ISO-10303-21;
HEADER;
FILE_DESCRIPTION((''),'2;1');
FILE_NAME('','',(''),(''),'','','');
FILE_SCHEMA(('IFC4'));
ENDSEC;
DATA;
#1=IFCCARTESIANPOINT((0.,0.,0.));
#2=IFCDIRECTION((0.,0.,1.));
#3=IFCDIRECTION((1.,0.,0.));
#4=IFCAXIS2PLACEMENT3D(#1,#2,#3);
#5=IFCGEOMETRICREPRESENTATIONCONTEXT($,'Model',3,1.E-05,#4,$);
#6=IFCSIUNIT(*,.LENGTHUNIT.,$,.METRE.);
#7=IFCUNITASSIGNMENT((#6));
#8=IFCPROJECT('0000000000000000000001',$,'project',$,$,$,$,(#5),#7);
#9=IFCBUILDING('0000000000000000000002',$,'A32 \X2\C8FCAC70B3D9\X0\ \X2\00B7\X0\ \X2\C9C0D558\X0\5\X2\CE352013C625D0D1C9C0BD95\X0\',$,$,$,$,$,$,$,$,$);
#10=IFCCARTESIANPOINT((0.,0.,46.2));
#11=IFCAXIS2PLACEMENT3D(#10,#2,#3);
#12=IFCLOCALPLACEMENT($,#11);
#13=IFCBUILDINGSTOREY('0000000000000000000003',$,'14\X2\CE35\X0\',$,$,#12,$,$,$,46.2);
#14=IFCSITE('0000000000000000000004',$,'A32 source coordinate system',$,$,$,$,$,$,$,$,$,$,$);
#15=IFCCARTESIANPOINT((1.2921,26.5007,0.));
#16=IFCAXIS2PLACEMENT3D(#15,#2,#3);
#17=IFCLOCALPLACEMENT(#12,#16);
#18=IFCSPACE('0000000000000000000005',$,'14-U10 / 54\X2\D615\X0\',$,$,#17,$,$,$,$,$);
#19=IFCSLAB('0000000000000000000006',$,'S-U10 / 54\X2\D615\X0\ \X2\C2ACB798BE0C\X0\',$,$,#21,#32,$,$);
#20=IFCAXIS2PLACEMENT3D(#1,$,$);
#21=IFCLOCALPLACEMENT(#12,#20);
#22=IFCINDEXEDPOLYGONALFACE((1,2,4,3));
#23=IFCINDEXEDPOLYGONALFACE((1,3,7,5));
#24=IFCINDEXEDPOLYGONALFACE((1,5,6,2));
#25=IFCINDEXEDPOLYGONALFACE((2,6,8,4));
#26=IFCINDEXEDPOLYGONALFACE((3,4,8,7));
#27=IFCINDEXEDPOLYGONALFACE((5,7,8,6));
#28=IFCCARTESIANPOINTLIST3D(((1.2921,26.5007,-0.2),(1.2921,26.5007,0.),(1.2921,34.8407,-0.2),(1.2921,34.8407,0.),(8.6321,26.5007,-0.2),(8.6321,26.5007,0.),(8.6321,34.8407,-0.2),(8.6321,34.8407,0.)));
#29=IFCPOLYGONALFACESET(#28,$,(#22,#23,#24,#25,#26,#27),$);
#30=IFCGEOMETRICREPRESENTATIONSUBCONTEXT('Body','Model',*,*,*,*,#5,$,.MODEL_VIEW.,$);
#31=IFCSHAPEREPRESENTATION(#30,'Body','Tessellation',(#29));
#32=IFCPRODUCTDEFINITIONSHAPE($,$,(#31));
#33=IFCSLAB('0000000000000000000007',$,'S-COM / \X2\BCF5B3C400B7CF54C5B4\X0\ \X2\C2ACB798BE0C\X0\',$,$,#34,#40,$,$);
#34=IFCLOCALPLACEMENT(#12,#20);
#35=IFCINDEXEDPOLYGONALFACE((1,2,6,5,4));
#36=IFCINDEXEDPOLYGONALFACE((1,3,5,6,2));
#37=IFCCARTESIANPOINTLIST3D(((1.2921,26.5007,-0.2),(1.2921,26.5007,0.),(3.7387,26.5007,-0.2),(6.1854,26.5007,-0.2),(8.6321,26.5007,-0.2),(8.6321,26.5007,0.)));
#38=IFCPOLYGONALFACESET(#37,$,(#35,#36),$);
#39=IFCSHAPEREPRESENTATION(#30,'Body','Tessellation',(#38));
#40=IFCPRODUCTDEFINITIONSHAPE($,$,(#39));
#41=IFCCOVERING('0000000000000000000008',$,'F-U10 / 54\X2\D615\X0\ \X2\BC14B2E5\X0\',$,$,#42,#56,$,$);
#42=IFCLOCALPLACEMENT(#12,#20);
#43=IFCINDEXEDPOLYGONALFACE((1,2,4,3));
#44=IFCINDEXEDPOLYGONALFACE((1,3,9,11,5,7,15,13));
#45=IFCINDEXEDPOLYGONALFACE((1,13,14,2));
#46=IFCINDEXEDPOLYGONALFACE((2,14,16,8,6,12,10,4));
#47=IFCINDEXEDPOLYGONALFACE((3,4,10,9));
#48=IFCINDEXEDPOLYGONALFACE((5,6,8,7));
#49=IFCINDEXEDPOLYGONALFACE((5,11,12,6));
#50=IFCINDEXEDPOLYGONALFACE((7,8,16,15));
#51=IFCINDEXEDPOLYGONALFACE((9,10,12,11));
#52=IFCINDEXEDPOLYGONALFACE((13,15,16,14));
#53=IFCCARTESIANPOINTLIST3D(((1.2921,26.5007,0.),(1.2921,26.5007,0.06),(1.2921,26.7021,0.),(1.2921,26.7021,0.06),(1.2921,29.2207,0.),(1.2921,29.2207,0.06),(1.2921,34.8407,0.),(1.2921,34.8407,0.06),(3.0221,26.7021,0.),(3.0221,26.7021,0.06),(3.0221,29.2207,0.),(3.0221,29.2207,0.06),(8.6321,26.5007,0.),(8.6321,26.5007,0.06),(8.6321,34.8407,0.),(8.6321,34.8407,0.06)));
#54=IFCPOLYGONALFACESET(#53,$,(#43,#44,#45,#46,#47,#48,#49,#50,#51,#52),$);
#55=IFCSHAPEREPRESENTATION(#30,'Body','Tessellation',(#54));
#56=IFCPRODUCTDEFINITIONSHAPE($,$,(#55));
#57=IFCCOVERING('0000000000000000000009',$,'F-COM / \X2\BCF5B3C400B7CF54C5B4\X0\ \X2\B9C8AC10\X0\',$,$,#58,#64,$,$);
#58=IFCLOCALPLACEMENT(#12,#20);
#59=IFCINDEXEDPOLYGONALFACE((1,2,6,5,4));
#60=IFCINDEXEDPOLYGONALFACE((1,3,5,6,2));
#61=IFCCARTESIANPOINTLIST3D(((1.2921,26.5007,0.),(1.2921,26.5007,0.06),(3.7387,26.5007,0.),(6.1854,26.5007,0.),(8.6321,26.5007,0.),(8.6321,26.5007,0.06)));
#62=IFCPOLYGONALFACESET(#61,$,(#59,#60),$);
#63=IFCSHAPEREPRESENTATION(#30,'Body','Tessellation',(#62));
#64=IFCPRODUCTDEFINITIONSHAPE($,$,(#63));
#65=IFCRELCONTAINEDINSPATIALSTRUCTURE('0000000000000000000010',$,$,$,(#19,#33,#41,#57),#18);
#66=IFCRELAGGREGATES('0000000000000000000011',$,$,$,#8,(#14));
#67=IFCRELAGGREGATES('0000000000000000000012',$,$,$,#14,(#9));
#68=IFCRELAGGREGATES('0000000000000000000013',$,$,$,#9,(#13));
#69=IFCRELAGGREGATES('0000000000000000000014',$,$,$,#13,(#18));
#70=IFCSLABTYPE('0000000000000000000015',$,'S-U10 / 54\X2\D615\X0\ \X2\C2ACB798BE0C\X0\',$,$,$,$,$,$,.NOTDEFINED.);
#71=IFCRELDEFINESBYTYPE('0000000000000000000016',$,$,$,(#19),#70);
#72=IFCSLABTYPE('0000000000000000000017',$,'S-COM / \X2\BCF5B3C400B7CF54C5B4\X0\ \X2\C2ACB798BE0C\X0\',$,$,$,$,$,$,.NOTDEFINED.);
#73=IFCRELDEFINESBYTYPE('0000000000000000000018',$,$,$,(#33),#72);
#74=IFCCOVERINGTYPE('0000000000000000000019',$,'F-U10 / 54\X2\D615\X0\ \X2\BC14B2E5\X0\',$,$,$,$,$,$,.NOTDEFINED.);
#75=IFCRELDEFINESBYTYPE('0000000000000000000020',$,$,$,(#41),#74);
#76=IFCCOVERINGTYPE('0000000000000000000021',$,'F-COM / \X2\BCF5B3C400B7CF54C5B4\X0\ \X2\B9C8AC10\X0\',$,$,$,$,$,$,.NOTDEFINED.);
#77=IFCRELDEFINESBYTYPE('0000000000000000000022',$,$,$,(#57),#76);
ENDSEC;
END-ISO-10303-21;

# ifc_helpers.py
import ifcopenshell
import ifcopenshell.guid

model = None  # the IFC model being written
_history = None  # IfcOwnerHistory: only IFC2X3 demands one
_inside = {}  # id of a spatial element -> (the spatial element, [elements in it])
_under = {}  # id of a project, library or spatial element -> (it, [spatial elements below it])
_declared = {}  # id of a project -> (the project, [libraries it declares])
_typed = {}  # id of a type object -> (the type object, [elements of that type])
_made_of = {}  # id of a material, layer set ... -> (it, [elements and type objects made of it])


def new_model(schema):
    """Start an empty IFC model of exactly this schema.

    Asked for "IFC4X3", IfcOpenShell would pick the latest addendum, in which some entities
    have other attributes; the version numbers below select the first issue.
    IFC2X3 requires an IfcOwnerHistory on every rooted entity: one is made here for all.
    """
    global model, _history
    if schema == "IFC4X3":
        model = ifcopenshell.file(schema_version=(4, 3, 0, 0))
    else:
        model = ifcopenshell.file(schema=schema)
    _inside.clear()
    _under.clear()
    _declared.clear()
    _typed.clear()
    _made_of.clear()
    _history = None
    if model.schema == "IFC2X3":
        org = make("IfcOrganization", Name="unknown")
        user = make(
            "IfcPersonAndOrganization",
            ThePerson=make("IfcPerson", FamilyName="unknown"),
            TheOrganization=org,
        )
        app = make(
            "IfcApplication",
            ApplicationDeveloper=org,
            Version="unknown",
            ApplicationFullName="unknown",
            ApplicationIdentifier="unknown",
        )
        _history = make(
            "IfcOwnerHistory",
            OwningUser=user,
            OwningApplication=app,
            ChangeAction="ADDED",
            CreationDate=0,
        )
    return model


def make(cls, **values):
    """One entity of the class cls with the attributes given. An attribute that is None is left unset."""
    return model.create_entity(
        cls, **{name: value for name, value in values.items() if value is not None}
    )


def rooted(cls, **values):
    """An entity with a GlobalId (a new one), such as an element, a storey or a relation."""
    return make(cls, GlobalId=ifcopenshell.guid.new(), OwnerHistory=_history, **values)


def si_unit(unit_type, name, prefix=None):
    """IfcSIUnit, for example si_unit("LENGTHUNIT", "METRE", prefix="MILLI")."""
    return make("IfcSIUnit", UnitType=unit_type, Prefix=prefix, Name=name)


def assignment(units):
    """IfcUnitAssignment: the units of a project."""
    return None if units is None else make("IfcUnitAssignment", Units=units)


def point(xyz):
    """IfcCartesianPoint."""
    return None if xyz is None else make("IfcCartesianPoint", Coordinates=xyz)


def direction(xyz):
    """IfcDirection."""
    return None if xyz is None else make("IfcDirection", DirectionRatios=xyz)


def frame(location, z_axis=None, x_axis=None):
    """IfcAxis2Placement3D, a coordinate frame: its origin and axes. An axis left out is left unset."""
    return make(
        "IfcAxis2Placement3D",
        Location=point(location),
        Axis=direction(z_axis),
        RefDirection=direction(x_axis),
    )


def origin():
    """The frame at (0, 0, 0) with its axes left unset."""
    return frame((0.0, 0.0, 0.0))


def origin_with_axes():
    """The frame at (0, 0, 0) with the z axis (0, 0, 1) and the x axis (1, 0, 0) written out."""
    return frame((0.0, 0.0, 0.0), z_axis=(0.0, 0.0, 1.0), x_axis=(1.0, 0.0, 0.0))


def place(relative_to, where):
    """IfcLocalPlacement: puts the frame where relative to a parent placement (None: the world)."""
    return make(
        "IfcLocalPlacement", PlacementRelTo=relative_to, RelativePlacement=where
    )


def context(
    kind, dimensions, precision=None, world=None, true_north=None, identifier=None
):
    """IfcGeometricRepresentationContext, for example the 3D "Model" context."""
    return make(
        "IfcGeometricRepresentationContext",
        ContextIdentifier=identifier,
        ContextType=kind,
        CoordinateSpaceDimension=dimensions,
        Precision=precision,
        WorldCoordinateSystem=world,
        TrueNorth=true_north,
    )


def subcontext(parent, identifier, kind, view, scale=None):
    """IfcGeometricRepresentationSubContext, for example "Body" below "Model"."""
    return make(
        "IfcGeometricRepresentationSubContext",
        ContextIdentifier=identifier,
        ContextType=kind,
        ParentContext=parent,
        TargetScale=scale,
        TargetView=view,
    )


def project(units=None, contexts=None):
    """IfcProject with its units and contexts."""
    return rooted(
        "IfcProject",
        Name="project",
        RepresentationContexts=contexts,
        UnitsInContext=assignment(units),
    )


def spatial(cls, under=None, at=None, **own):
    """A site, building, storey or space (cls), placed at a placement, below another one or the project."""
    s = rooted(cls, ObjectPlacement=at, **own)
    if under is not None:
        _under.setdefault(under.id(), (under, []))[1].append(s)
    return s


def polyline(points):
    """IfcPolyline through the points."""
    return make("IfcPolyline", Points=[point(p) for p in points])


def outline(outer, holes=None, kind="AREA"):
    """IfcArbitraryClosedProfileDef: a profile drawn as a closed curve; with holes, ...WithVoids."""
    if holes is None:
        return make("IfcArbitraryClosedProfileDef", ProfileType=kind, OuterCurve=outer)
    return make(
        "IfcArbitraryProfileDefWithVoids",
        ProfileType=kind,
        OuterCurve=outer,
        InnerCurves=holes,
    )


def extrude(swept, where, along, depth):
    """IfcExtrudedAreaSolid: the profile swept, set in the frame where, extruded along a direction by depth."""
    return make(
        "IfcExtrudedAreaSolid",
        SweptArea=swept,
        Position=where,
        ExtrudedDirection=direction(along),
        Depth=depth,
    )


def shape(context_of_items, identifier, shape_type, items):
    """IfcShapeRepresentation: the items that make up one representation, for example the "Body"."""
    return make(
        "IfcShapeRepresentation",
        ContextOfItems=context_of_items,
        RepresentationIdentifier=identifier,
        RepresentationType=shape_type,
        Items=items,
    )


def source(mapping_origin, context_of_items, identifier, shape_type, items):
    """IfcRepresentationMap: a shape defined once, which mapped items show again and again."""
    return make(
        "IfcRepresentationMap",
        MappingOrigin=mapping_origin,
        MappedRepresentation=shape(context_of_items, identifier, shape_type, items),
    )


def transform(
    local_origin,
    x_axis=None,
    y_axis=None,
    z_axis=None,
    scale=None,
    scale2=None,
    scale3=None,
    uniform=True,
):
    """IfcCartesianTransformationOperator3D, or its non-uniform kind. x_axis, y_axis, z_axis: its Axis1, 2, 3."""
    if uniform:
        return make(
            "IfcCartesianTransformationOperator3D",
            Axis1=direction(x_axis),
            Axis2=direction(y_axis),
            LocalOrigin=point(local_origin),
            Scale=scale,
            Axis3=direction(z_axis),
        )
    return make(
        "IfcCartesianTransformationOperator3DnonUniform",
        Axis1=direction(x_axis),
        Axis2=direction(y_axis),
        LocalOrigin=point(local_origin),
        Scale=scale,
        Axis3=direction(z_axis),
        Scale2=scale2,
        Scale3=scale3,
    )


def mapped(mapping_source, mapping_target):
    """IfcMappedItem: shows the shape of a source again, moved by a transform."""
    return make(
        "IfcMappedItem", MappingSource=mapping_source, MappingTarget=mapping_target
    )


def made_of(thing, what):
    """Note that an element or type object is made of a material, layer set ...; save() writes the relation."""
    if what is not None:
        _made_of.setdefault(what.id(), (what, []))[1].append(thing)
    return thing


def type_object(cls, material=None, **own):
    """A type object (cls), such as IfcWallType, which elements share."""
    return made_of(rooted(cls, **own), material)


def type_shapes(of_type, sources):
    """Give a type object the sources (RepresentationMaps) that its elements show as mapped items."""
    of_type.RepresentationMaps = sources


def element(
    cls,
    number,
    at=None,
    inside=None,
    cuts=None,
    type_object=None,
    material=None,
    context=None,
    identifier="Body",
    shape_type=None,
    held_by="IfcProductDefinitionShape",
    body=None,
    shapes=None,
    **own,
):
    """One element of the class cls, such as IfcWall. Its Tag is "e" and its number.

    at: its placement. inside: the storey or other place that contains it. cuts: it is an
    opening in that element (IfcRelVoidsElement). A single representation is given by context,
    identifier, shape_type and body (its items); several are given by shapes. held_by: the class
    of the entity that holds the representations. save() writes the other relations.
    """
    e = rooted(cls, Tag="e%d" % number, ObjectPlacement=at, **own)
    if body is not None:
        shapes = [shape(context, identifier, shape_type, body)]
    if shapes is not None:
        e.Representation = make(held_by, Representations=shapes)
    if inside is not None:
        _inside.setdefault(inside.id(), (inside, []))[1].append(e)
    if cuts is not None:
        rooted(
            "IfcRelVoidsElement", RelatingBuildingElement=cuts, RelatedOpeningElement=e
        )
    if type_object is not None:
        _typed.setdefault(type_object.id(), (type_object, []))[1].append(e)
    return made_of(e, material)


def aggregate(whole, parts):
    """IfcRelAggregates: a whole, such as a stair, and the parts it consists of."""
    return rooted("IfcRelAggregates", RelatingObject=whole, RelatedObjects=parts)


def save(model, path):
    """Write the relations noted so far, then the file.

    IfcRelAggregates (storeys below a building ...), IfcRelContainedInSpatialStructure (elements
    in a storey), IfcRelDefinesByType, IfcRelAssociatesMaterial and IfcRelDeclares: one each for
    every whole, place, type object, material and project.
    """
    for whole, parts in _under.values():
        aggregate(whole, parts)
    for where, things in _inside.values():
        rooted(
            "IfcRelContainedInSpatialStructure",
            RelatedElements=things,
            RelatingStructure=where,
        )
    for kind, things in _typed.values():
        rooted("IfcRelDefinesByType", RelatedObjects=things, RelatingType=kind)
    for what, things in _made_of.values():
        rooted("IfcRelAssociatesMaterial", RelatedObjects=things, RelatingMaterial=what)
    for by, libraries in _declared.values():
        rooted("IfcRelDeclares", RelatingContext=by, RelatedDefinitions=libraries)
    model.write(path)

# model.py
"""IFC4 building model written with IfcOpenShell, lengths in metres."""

from ifc_helpers import new_model, si_unit, frame, origin, origin_with_axes, place, context, subcontext, project, spatial, polyline, outline, extrude, source, transform, mapped, type_object, type_shapes, element, save


model = new_model("IFC4")

# Units and contexts
model_context = context("Model", 3, precision=1e-05, world=origin_with_axes())
body_context = subcontext(model_context, "Body", "Model", "MODEL_VIEW")
ifc_project = project(units=[si_unit("LENGTHUNIT", "METRE")], contexts=[model_context])

# Site, building, storey, space
storey_placement = place(None, frame((0.0, 0.0, 46.2), z_axis=(0.0, 0.0, 1.0), x_axis=(1.0, 0.0, 0.0)))
space_placement = place(storey_placement, frame((1.2921, 26.5007, 0.0), z_axis=(0.0, 0.0, 1.0), x_axis=(1.0, 0.0, 0.0)))
site = spatial("IfcSite", under=ifc_project, Name="A32 source coordinate system")
building = spatial("IfcBuilding", under=site, Name="A32 주거동 · 지하5층–옥탑지붕")
storey = spatial("IfcBuildingStorey", under=building, at=storey_placement, Name="14층", Elevation=46.2)
space = spatial("IfcSpace", under=storey, at=space_placement, Name="14-U10 / 54형")

# Slabs
slab_type_1 = type_object("IfcSlabType", Name="S-U10 / 54형 슬래브", PredefinedType="NOTDEFINED")
shared_shape_1 = source(origin(), body_context, "Body", "SweptSolid", [
    extrude(outline(polyline([(0.0, 0.0), (0.0, 8.34), (7.34, 8.34), (7.34, 0.0), (0.0, 0.0)])), frame((0.0, 0.0, -0.2)), (0.0, 0.0, 1.0), 0.2),
])
type_shapes(slab_type_1, [shared_shape_1])
slab_1_placement = place(space_placement, origin_with_axes())
element("IfcSlab", 1, at=slab_1_placement, inside=space, type_object=slab_type_1, Name="S-U10 / 54형 슬래브", context=body_context, shape_type="MappedRepresentation", body=[
    mapped(shared_shape_1, transform((0.0, 0.0, 0.0), scale=1.0)),
])
slab_type_2 = type_object("IfcSlabType", Name="S-COM / 복도·코어 슬래브", PredefinedType="NOTDEFINED")
shared_shape_2 = source(origin(), body_context, "Body", "SweptSolid", [
    extrude(outline(polyline([(7.34, 0.0), (7.34, 0.0), (0.0, 0.0), (0.0, 0.0), (7.34, 0.0)])), frame((0.0, 0.0, -0.2)), (0.0, 0.0, 1.0), 0.2),
])
type_shapes(slab_type_2, [shared_shape_2])
slab_2_placement = place(space_placement, origin_with_axes())
element("IfcSlab", 2, at=slab_2_placement, inside=space, type_object=slab_type_2, Name="S-COM / 복도·코어 슬래브", context=body_context, shape_type="MappedRepresentation", body=[
    mapped(shared_shape_2, transform((0.0, 0.0, 0.0), scale=1.0)),
])

# Coverings
covering_type_1 = type_object("IfcCoveringType", Name="F-U10 / 54형 바닥", PredefinedType="NOTDEFINED")
shared_shape_3 = source(origin(), body_context, "Body", "SweptSolid", [
    extrude(outline(polyline([(7.34, 0.0), (0.0, 0.0), (0.0, 0.2014), (1.73, 0.2014), (1.73, 2.72), (0.0, 2.72), (0.0, 8.34), (7.34, 8.34), (7.34, 0.0)])), origin(), (0.0, 0.0, 1.0), 0.06),
])
type_shapes(covering_type_1, [shared_shape_3])
covering_1_placement = place(space_placement, origin_with_axes())
element("IfcCovering", 3, at=covering_1_placement, inside=space, type_object=covering_type_1, Name="F-U10 / 54형 바닥", context=body_context, shape_type="MappedRepresentation", body=[
    mapped(shared_shape_3, transform((0.0, 0.0, 0.0), scale=1.0)),
])
covering_type_2 = type_object("IfcCoveringType", Name="F-COM / 복도·코어 마감", PredefinedType="NOTDEFINED")
shared_shape_4 = source(origin(), body_context, "Body", "SweptSolid", [
    extrude(outline(polyline([(7.34, 0.0), (7.34, 0.0), (0.0, 0.0), (0.0, 0.0), (7.34, 0.0)])), origin(), (0.0, 0.0, 1.0), 0.06),
])
type_shapes(covering_type_2, [shared_shape_4])
covering_2_placement = place(space_placement, origin_with_axes())
element("IfcCovering", 4, at=covering_2_placement, inside=space, type_object=covering_type_2, Name="F-COM / 복도·코어 마감", context=body_context, shape_type="MappedRepresentation", body=[
    mapped(shared_shape_4, transform((0.0, 0.0, 0.0), scale=1.0)),
])

save(model, "model.ifc")
